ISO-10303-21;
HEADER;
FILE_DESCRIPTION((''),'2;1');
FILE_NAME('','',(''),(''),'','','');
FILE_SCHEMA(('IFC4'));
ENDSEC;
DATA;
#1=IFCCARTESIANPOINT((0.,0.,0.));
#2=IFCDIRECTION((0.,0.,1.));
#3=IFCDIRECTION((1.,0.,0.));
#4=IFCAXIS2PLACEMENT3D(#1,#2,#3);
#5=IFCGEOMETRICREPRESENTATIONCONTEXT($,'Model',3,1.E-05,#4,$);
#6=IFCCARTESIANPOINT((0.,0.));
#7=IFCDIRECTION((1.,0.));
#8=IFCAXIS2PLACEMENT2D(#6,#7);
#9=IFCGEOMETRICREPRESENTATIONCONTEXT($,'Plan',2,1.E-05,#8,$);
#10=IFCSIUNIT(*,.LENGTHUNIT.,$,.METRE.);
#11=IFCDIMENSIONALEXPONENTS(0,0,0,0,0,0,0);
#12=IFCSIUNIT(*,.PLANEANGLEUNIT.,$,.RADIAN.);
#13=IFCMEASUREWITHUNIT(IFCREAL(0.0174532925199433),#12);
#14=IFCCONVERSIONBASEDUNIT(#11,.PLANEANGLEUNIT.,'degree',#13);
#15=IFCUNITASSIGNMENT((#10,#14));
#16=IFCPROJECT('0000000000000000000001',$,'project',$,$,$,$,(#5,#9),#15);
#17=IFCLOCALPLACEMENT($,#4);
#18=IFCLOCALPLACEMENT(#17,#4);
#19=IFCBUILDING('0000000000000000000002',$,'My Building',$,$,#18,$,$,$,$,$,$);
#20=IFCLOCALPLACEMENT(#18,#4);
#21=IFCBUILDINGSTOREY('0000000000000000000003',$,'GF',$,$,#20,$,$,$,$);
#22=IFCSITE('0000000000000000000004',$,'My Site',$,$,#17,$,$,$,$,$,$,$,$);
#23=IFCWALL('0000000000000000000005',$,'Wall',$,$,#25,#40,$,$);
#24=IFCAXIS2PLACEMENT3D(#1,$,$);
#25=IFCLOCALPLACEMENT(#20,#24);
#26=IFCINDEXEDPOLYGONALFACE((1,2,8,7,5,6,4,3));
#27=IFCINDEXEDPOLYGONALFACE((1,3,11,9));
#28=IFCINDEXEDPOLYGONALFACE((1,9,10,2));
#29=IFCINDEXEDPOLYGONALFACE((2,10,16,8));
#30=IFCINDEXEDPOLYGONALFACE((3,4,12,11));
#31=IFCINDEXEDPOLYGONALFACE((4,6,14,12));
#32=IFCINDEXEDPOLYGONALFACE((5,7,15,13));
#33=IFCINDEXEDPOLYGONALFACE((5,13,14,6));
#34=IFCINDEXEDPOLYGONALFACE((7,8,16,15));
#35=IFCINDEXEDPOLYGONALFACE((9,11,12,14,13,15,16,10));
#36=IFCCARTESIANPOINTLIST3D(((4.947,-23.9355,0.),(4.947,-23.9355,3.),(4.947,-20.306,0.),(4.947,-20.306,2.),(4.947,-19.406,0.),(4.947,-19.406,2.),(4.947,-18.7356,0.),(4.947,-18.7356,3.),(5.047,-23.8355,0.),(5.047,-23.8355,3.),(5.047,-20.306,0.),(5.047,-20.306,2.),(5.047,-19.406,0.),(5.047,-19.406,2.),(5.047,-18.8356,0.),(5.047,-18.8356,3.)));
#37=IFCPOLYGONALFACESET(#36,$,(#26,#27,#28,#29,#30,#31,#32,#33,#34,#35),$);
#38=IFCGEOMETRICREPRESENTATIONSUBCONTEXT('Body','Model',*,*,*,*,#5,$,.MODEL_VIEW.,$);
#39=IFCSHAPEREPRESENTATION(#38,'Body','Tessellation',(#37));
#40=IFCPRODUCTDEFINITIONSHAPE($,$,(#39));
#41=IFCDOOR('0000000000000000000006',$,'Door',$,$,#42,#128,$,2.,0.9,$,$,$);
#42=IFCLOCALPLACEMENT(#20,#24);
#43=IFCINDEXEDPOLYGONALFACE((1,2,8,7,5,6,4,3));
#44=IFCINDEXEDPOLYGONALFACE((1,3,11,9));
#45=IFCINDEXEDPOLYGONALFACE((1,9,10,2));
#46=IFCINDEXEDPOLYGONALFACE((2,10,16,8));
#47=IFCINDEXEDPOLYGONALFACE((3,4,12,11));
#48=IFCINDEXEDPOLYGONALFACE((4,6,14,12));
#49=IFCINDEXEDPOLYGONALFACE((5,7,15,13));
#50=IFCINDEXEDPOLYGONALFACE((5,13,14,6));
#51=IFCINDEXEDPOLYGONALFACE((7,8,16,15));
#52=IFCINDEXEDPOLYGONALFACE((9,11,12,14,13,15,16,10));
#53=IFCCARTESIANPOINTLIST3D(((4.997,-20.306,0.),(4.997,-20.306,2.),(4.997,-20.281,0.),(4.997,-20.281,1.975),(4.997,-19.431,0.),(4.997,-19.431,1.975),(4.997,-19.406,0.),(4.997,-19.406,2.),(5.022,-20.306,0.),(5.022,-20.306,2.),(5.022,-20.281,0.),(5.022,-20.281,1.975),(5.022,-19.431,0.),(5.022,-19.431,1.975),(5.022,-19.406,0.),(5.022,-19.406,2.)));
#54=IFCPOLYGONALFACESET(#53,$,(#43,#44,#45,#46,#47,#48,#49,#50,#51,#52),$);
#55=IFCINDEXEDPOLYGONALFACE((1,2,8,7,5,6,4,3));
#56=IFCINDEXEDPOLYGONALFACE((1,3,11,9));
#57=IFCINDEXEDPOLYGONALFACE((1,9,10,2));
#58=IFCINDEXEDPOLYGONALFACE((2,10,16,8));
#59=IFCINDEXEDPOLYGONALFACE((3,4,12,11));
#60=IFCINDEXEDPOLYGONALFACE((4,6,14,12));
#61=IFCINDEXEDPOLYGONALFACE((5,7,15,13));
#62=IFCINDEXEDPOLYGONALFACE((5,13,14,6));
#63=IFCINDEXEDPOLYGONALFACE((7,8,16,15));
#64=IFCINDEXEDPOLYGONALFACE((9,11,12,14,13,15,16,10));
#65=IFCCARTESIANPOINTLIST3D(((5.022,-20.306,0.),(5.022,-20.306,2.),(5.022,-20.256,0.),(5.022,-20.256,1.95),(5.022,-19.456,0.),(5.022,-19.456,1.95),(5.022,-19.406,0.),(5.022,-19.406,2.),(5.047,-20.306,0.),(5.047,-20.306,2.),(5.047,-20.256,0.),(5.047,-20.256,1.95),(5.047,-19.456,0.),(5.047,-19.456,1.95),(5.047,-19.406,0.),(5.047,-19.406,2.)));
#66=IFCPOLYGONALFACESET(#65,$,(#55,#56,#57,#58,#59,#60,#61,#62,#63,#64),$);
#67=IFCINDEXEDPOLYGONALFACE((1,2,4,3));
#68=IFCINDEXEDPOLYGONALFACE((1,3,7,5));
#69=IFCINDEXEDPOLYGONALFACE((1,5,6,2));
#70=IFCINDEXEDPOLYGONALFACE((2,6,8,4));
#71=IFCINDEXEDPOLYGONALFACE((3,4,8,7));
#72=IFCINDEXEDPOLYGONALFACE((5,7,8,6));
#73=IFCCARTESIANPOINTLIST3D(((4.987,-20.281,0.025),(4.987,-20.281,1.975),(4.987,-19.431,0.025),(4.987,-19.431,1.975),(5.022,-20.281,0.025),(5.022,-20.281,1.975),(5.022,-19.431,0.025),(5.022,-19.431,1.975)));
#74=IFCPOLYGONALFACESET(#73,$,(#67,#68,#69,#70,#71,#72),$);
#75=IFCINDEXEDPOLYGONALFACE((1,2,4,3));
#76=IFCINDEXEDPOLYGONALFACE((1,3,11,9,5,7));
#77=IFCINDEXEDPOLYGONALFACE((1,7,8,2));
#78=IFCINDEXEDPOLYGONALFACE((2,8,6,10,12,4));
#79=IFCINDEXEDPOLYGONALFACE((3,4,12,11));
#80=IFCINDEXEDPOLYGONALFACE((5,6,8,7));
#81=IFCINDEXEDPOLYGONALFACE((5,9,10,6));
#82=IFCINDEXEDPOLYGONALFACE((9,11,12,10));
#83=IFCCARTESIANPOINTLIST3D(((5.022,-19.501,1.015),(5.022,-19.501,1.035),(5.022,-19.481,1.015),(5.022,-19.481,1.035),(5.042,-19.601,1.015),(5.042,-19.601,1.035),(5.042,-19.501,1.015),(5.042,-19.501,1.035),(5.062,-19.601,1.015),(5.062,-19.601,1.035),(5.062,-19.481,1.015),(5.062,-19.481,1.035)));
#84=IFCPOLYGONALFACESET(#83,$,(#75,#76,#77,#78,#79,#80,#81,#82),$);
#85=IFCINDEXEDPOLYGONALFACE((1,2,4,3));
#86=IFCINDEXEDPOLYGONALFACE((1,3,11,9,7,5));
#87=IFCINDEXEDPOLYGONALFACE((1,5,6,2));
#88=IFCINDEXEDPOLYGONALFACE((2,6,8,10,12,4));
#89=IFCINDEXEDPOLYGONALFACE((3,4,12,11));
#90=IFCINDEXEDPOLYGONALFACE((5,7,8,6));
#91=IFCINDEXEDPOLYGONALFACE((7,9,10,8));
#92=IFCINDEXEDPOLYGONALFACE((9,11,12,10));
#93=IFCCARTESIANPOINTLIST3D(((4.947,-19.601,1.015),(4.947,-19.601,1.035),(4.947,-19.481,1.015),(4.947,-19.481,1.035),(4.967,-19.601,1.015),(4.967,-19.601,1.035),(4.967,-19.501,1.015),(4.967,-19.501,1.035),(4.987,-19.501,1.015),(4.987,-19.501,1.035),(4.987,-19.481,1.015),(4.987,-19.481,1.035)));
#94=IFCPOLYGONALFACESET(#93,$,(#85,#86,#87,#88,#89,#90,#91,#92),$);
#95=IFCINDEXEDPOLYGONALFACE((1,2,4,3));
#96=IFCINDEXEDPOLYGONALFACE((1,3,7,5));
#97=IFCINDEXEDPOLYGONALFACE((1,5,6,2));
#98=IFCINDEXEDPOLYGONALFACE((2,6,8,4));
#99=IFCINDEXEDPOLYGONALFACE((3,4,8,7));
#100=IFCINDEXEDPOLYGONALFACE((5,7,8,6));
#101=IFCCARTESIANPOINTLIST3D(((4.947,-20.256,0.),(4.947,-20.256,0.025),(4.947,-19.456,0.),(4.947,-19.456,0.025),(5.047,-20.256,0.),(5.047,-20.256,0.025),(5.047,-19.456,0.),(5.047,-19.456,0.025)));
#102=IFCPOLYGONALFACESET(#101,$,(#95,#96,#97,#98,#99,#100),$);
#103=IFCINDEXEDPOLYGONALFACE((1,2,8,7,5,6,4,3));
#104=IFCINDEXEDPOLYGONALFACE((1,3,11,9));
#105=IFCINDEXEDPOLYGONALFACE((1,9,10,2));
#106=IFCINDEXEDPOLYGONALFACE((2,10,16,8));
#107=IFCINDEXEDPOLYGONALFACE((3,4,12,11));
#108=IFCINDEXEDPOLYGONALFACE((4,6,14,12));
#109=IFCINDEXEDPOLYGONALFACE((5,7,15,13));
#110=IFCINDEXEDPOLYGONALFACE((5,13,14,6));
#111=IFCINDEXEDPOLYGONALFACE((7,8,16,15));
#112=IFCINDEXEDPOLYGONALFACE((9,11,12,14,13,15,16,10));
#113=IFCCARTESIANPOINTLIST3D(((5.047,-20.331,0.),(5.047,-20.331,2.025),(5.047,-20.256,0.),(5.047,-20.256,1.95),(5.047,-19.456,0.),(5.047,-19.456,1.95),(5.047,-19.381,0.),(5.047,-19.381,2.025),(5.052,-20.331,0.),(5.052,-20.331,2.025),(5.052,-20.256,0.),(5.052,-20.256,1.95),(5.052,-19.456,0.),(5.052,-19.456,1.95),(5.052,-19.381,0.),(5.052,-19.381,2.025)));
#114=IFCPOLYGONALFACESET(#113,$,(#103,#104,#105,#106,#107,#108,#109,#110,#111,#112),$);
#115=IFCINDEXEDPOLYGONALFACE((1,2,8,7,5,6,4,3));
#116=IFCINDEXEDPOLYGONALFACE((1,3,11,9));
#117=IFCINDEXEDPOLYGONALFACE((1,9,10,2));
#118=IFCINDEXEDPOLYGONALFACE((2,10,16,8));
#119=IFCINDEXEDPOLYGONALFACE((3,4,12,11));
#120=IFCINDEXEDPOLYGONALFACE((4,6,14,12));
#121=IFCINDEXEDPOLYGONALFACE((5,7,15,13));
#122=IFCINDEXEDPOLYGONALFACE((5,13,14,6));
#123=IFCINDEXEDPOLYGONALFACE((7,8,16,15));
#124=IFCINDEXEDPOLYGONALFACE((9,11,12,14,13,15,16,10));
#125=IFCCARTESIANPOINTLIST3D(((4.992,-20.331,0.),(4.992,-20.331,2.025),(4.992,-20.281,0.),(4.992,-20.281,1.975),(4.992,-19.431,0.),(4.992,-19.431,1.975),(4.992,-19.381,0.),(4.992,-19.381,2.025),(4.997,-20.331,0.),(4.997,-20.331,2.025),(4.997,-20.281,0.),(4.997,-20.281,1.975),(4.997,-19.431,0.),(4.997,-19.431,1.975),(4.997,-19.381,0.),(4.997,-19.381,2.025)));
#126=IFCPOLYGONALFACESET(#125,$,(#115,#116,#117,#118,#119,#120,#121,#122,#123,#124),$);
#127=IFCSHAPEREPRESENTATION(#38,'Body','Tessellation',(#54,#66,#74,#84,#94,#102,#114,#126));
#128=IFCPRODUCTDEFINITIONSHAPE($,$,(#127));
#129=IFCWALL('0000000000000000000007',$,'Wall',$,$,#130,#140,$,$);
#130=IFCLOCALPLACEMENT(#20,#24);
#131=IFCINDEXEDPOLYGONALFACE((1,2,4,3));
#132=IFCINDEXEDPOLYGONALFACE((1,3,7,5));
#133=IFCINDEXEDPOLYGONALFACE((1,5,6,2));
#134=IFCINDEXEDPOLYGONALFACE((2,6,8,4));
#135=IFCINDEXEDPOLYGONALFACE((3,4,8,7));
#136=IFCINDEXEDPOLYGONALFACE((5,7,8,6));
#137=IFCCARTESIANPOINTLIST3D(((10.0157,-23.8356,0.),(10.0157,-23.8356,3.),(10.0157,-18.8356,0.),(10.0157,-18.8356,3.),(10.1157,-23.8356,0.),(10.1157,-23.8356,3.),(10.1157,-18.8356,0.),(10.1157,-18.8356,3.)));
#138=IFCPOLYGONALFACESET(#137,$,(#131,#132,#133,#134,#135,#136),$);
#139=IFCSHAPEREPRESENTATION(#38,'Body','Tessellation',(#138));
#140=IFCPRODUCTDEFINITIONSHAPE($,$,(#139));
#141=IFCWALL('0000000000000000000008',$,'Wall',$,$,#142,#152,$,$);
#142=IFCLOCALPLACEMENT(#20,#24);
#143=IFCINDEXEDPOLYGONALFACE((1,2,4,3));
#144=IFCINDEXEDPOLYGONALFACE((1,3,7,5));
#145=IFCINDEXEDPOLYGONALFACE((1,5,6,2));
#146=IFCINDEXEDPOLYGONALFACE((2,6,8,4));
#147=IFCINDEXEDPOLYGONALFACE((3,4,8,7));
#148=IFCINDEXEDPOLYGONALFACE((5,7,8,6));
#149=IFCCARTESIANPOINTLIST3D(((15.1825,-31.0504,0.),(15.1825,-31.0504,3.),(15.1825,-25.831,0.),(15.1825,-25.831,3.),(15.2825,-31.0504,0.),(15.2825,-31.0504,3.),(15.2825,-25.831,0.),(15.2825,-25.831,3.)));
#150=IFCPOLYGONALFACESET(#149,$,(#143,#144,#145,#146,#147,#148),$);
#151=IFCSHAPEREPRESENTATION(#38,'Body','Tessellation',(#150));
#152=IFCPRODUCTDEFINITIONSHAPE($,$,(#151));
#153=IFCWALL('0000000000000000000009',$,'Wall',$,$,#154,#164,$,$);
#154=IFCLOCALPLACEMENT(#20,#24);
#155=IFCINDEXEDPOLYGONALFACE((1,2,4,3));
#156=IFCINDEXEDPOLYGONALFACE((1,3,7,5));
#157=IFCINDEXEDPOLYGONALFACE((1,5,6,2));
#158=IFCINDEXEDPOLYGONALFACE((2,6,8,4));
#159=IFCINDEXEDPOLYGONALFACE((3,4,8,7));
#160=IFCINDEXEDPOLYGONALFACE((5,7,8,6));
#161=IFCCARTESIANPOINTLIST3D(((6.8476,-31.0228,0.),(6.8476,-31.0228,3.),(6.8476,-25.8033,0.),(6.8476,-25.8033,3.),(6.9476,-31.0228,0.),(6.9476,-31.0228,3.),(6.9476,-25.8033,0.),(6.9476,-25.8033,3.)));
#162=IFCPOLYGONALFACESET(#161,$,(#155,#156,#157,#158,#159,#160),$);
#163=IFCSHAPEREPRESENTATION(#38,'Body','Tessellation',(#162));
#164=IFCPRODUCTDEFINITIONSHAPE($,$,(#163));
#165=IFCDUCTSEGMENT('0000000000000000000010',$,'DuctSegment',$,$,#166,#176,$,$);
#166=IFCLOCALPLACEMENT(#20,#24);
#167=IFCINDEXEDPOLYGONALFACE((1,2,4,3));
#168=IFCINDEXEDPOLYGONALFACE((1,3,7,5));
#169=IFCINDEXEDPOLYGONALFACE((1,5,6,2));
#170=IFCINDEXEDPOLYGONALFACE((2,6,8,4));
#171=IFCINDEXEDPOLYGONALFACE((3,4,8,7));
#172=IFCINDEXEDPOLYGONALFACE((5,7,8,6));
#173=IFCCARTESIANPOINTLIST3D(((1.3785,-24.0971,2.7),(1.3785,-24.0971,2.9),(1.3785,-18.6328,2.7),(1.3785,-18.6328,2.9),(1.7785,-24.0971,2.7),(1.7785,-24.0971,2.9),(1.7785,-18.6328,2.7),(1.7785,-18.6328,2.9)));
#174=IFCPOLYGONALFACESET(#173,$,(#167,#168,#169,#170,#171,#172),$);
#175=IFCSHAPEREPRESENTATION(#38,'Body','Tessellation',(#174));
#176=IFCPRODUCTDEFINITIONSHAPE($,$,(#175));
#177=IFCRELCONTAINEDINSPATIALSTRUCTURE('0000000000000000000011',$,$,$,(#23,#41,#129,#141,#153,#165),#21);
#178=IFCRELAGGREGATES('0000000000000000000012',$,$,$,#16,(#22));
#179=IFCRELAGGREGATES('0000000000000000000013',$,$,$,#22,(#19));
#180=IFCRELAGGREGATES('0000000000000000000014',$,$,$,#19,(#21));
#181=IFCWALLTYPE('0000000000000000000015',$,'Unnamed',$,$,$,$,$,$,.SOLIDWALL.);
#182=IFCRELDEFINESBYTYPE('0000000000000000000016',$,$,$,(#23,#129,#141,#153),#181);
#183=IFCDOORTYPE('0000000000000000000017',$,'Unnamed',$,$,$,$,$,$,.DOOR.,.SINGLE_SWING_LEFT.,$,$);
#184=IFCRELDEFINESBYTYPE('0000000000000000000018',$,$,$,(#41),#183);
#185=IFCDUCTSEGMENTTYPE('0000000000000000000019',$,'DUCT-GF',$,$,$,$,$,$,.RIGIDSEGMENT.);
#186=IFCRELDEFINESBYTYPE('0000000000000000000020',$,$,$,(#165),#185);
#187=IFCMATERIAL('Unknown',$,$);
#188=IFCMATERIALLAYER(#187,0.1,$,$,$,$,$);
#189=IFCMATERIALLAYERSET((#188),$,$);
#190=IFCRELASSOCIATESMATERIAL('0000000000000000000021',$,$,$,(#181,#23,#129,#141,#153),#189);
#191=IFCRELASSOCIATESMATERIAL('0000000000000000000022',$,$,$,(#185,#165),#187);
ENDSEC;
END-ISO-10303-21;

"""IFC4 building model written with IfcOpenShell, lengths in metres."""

from ifc_helpers import new_model, entity, si_unit, converted_unit, frame, origin_with_axes, origin_2d_with_axis, place, context, subcontext, project, spatial, line, indexed_curve, rectangle, outline, extrude, shape, source, transform, mapped, material, layer, layer_set, layer_usage, material_profile, profile_set, profile_usage, type_object, type_shapes, element, fill, save


model = new_model("IFC4")

# Units and contexts
model_context = context("Model", 3, precision=1e-05, world=origin_with_axes())
plan_context = context("Plan", 2, precision=1e-05, world=origin_2d_with_axis())
body_context_1 = subcontext(model_context, "Body", "Model", "MODEL_VIEW")
body_context_2 = subcontext(plan_context, "Body", "Plan", "PLAN_VIEW")
ifc_project = project(units=[si_unit("LENGTHUNIT", "METRE"), converted_unit("PLANEANGLEUNIT", "degree", entity("IfcReal", 0.0174532925199433), si_unit("PLANEANGLEUNIT", "RADIAN"), dimensions=[0, 0, 0, 0, 0, 0, 0])], contexts=[model_context, plan_context])

# Site, building, storey
site_placement = place(None, origin_with_axes())
site = spatial("IfcSite", under=ifc_project, at=site_placement, Name="My Site")
building_placement = place(site_placement, origin_with_axes())
building = spatial("IfcBuilding", under=site, at=building_placement, Name="My Building")
storey_placement = place(building_placement, origin_with_axes())
storey = spatial("IfcBuildingStorey", under=building, at=storey_placement, Name="GF")

# Shared definitions
ifc_material = material(Name="Unknown")
ifc_layer = layer(ifc_material, 0.1)
ifc_layer_set = layer_set([ifc_layer])
wall_type = type_object("IfcWallType", Name="Unnamed", PredefinedType="SOLIDWALL", material=ifc_layer_set)

# Shared definitions
shared_shape_1 = source(origin_with_axes(), body_context_1, "Body", "SweptSolid", [
    extrude(outline(indexed_curve([(0.0, 0.0), (0.9, 0.0), (0.9, 2.0), (0.0, 2.0)], segments=[line(1, 2, 3, 4, 1)])), frame((0.0, -0.6, 0.0), z_axis=(0.0, -1.0, 0.0), x_axis=(1.0, 0.0, 0.0)), (0.0, 0.0, -1.0), 1.2),
])
door_type = type_object("IfcDoorType", Name="Unnamed", OperationType="SINGLE_SWING_LEFT", PredefinedType="DOOR")
shared_shape_2 = source(origin_with_axes(), body_context_1, "Body", "SweptSolid", [
    extrude(outline(indexed_curve([(0.0, 0.0), (0.0, 2.0), (0.9, 2.0), (0.9, 0.0), (0.875, 0.0), (0.875, 1.975), (0.025, 1.975), (0.025, 0.0)], segments=[line(1, 2, 3, 4, 5, 6, 7, 8, 1)])), frame((0.0, 0.025, 0.0), z_axis=(0.0, -1.0, 0.0), x_axis=(1.0, 0.0, 0.0)), (0.0, 0.0, -1.0), 0.025),
    extrude(outline(indexed_curve([(0.0, 0.0), (0.0, 2.0), (0.9, 2.0), (0.9, 0.0), (0.85, 0.0), (0.85, 1.95), (0.05, 1.95), (0.05, 0.0)], segments=[line(1, 2, 3, 4, 5, 6, 7, 8, 1)])), frame((0.0, 0.0, 0.0), z_axis=(0.0, -1.0, 0.0), x_axis=(1.0, 0.0, 0.0)), (0.0, 0.0, -1.0), 0.025),
    extrude(outline(indexed_curve([(0.0, 0.0), (0.85, 0.0), (0.85, 0.035), (0.0, 0.035)], segments=[line(1, 2, 3, 4, 1)])), frame((0.025, 0.025, 0.025), z_axis=(0.0, 0.0, 1.0), x_axis=(1.0, 0.0, 0.0)), (0.0, 0.0, 1.0), 1.95),
    extrude(outline(indexed_curve([(0.0, 0.0), (0.0, -0.04), (-0.12, -0.04), (-0.12, -0.02), (-0.02, -0.02), (-0.02, 0.0)], segments=[line(1, 2, 3, 4, 5, 6, 1)])), frame((0.825, 0.025, 1.015), z_axis=(0.0, 0.0, 1.0), x_axis=(1.0, 0.0, 0.0)), (0.0, 0.0, 1.0), 0.02),
    extrude(outline(indexed_curve([(0.0, 0.0), (0.0, 0.04), (-0.12, 0.04), (-0.12, 0.02), (-0.02, 0.02), (-0.02, 0.0)], segments=[line(1, 2, 3, 4, 5, 6, 1)])), frame((0.825, 0.06, 1.015), z_axis=(0.0, 0.0, 1.0), x_axis=(1.0, 0.0, 0.0)), (0.0, 0.0, 1.0), 0.02),
    extrude(outline(indexed_curve([(0.0, 0.0), (0.8, 0.0), (0.8, 0.1), (0.0, 0.1)], segments=[line(1, 2, 3, 4, 1)])), frame((0.05, 0.0, 0.0), z_axis=(0.0, 0.0, 1.0), x_axis=(1.0, 0.0, 0.0)), (0.0, 0.0, 1.0), 0.025),
    extrude(outline(indexed_curve([(0.0, 0.0), (0.0, 2.025), (0.95, 2.025), (0.95, 0.0), (0.875, 0.0), (0.875, 1.95), (0.075, 1.95), (0.075, 0.0)], segments=[line(1, 2, 3, 4, 5, 6, 7, 8, 1)])), frame((-0.025, -0.005, 0.0), z_axis=(0.0, -1.0, 0.0), x_axis=(1.0, 0.0, 0.0)), (0.0, 0.0, -1.0), 0.005),
    extrude(outline(indexed_curve([(0.0, 0.0), (0.0, 2.025), (0.95, 2.025), (0.95, 0.0), (0.9, 0.0), (0.9, 1.975), (0.05, 1.975), (0.05, 0.0)], segments=[line(1, 2, 3, 4, 5, 6, 7, 8, 1)])), frame((-0.025, 0.05, 0.0), z_axis=(0.0, -1.0, 0.0), x_axis=(1.0, 0.0, 0.0)), (0.0, 0.0, -1.0), 0.005),
])
shared_shape_3 = source(origin_with_axes(), body_context_2, "Body", "Curve2D", [
    entity("IfcIndexedPolyCurve", entity("IfcCartesianPointList2D", [[0.0, 0.0], [0.0, 0.05], [0.025, 0.05], [0.025, 0.025], [0.05, 0.025], [0.05, 0.0]]), [entity("IfcLineIndex", [1, 2, 3, 4, 5, 6, 1])]),
    entity("IfcIndexedPolyCurve", entity("IfcCartesianPointList2D", [[0.9, 0.0], [0.9, 0.05], [0.875, 0.05], [0.875, 0.025], [0.85, 0.025], [0.85, 0.0]]), [entity("IfcLineIndex", [1, 2, 3, 4, 5, 6, 1])]),
    entity("IfcTrimmedCurve", entity("IfcEllipse", entity("IfcAxis2Placement2D", entity("IfcCartesianPoint", [0.06, 0.05]), entity("IfcDirection", [1.0, 0.0])), 0.815, 0.85), [entity("IfcCartesianPoint", [0.875, 0.05])], [entity("IfcCartesianPoint", [0.06, 0.9])], True, "CARTESIAN"),
    entity("IfcIndexedPolyCurve", entity("IfcCartesianPointList2D", [[0.025, 0.05], [0.06, 0.05], [0.06, 0.9], [0.025, 0.9]]), [entity("IfcLineIndex", [1, 2, 3, 4, 1])]),
])
type_shapes(door_type, [shared_shape_2, shared_shape_3])

# Wall, opening, door
ifc_layer_usage_1 = layer_usage(ifc_layer_set, "AXIS2", "POSITIVE", 0.0)
wall_1_placement = place(storey_placement, frame((5.047, -23.8355, 0.0), z_axis=(0.0, 0.0, 1.0), x_axis=(0.0, 1.0, 0.0)))
wall_1 = element("IfcWall", 1, at=wall_1_placement, inside=storey, type_object=wall_type, material=ifc_layer_usage_1, Name="Wall", context=body_context_1, shape_type="SweptSolid", body=[
    extrude(outline(indexed_curve([(0.0, 0.0), (-0.1, 0.1), (5.1, 0.1), (5.0, 0.0)], segments=[line(1, 2, 3, 4, 1)])), origin_with_axes(), (0.0, 0.0, 1.0), 3.0),
])
opening_1_placement = place(wall_1_placement, frame((3.5295, 0.0, 0.0), z_axis=(0.0, 0.0, 1.0), x_axis=(1.0, 0.0, 0.0)))
opening_1 = element("IfcOpeningElement", 2, at=opening_1_placement, cuts=wall_1, PredefinedType="OPENING", context=body_context_1, shape_type="MappedRepresentation", body=[
    mapped(shared_shape_1, transform((0.0, 0.0, 0.0), x_axis=(1.0, 0.0, 0.0), y_axis=(0.0, 1.0, 0.0), z_axis=(0.0, 0.0, 1.0), scale=1.0)),
])
door_1_placement = place(opening_1_placement, frame((0.0, 0.0, 0.0), z_axis=(0.0, 0.0, 1.0), x_axis=(1.0, 0.0, 0.0)))
door_1 = element("IfcDoor", 3, at=door_1_placement, inside=storey, type_object=door_type, Name="Door", OverallHeight=2.0, OverallWidth=0.9, shapes=[
    shape(body_context_1, "Body", "MappedRepresentation", [mapped(shared_shape_2, transform((0.0, 0.0, 0.0), x_axis=(1.0, 0.0, 0.0), y_axis=(0.0, 1.0, 0.0), z_axis=(0.0, 0.0, 1.0), scale=1.0))]),
    shape(body_context_2, "Body", "MappedRepresentation", [mapped(shared_shape_3, transform((0.0, 0.0, 0.0), x_axis=(1.0, 0.0, 0.0), y_axis=(0.0, 1.0, 0.0), z_axis=(0.0, 0.0, 1.0), scale=1.0))]),
])
fill(opening_1, door_1)

# Walls
ifc_layer_usage_2 = layer_usage(ifc_layer_set, "AXIS2", "POSITIVE", 0.0)
wall_2_placement = place(storey_placement, frame((10.0157, -18.8356, 0.0), z_axis=(0.0, 0.0, 1.0), x_axis=(0.0, -1.0, 0.0)))
element("IfcWall", 4, at=wall_2_placement, inside=storey, type_object=wall_type, material=ifc_layer_usage_2, Name="Wall", context=body_context_1, shape_type="SweptSolid", body=[
    extrude(outline(indexed_curve([(0.0, 0.0), (0.0, 0.1), (5.0, 0.1), (5.0, 0.0)], segments=[line(1, 2, 3, 4, 1)])), origin_with_axes(), (0.0, 0.0, 1.0), 3.0),
])
ifc_layer_usage_3 = layer_usage(ifc_layer_set, "AXIS2", "POSITIVE", 0.0)
wall_3_placement = place(storey_placement, frame((15.1825, -25.831, 0.0), z_axis=(0.0, 0.0, 1.0), x_axis=(0.0, -1.0, 0.0)))
element("IfcWall", 5, at=wall_3_placement, inside=storey, type_object=wall_type, material=ifc_layer_usage_3, Name="Wall", context=body_context_1, shape_type="SweptSolid", body=[
    extrude(outline(indexed_curve([(0.0, 0.0), (0.0, 0.1), (5.2194, 0.1), (5.2194, 0.0)], segments=[line(1, 2, 3, 4, 1)])), origin_with_axes(), (0.0, 0.0, 1.0), 3.0),
])
ifc_layer_usage_4 = layer_usage(ifc_layer_set, "AXIS2", "POSITIVE", 0.0)
wall_4_placement = place(storey_placement, frame((6.8476, -25.8033, 0.0), z_axis=(0.0, 0.0, 1.0), x_axis=(0.0, -1.0, 0.0)))
element("IfcWall", 6, at=wall_4_placement, inside=storey, type_object=wall_type, material=ifc_layer_usage_4, Name="Wall", context=body_context_1, shape_type="SweptSolid", body=[
    extrude(outline(indexed_curve([(0.0, 0.0), (0.0, 0.1), (5.2195, 0.1), (5.2195, 0.0)], segments=[line(1, 2, 3, 4, 1)])), origin_with_axes(), (0.0, 0.0, 1.0), 3.0),
])

# Duct segment
ifc_material_profile_1 = material_profile(ifc_material, rectangle(XDim=0.4, YDim=0.2))
ifc_profile_set_1 = profile_set([ifc_material_profile_1])
ifc_profile_usage_1 = profile_usage(ifc_profile_set_1, cardinal=5)
duct_segment_type = type_object("IfcDuctSegmentType", Name="DUCT-GF", PredefinedType="RIGIDSEGMENT", material=ifc_profile_set_1)
duct_segment_1_placement = place(storey_placement, frame((1.5785, -18.6328, 2.8), z_axis=(0.0, -1.0, 0.0), x_axis=(1.0, 0.0, 0.0)))
element("IfcDuctSegment", 7, at=duct_segment_1_placement, inside=storey, type_object=duct_segment_type, material=ifc_profile_usage_1, Name="DuctSegment", context=body_context_1, shape_type="SweptSolid", body=[
    extrude(rectangle(XDim=0.4, YDim=0.2), origin_with_axes(), (0.0, 0.0, 1.0), 5.4642),
])

save(model, "model.ifc")
